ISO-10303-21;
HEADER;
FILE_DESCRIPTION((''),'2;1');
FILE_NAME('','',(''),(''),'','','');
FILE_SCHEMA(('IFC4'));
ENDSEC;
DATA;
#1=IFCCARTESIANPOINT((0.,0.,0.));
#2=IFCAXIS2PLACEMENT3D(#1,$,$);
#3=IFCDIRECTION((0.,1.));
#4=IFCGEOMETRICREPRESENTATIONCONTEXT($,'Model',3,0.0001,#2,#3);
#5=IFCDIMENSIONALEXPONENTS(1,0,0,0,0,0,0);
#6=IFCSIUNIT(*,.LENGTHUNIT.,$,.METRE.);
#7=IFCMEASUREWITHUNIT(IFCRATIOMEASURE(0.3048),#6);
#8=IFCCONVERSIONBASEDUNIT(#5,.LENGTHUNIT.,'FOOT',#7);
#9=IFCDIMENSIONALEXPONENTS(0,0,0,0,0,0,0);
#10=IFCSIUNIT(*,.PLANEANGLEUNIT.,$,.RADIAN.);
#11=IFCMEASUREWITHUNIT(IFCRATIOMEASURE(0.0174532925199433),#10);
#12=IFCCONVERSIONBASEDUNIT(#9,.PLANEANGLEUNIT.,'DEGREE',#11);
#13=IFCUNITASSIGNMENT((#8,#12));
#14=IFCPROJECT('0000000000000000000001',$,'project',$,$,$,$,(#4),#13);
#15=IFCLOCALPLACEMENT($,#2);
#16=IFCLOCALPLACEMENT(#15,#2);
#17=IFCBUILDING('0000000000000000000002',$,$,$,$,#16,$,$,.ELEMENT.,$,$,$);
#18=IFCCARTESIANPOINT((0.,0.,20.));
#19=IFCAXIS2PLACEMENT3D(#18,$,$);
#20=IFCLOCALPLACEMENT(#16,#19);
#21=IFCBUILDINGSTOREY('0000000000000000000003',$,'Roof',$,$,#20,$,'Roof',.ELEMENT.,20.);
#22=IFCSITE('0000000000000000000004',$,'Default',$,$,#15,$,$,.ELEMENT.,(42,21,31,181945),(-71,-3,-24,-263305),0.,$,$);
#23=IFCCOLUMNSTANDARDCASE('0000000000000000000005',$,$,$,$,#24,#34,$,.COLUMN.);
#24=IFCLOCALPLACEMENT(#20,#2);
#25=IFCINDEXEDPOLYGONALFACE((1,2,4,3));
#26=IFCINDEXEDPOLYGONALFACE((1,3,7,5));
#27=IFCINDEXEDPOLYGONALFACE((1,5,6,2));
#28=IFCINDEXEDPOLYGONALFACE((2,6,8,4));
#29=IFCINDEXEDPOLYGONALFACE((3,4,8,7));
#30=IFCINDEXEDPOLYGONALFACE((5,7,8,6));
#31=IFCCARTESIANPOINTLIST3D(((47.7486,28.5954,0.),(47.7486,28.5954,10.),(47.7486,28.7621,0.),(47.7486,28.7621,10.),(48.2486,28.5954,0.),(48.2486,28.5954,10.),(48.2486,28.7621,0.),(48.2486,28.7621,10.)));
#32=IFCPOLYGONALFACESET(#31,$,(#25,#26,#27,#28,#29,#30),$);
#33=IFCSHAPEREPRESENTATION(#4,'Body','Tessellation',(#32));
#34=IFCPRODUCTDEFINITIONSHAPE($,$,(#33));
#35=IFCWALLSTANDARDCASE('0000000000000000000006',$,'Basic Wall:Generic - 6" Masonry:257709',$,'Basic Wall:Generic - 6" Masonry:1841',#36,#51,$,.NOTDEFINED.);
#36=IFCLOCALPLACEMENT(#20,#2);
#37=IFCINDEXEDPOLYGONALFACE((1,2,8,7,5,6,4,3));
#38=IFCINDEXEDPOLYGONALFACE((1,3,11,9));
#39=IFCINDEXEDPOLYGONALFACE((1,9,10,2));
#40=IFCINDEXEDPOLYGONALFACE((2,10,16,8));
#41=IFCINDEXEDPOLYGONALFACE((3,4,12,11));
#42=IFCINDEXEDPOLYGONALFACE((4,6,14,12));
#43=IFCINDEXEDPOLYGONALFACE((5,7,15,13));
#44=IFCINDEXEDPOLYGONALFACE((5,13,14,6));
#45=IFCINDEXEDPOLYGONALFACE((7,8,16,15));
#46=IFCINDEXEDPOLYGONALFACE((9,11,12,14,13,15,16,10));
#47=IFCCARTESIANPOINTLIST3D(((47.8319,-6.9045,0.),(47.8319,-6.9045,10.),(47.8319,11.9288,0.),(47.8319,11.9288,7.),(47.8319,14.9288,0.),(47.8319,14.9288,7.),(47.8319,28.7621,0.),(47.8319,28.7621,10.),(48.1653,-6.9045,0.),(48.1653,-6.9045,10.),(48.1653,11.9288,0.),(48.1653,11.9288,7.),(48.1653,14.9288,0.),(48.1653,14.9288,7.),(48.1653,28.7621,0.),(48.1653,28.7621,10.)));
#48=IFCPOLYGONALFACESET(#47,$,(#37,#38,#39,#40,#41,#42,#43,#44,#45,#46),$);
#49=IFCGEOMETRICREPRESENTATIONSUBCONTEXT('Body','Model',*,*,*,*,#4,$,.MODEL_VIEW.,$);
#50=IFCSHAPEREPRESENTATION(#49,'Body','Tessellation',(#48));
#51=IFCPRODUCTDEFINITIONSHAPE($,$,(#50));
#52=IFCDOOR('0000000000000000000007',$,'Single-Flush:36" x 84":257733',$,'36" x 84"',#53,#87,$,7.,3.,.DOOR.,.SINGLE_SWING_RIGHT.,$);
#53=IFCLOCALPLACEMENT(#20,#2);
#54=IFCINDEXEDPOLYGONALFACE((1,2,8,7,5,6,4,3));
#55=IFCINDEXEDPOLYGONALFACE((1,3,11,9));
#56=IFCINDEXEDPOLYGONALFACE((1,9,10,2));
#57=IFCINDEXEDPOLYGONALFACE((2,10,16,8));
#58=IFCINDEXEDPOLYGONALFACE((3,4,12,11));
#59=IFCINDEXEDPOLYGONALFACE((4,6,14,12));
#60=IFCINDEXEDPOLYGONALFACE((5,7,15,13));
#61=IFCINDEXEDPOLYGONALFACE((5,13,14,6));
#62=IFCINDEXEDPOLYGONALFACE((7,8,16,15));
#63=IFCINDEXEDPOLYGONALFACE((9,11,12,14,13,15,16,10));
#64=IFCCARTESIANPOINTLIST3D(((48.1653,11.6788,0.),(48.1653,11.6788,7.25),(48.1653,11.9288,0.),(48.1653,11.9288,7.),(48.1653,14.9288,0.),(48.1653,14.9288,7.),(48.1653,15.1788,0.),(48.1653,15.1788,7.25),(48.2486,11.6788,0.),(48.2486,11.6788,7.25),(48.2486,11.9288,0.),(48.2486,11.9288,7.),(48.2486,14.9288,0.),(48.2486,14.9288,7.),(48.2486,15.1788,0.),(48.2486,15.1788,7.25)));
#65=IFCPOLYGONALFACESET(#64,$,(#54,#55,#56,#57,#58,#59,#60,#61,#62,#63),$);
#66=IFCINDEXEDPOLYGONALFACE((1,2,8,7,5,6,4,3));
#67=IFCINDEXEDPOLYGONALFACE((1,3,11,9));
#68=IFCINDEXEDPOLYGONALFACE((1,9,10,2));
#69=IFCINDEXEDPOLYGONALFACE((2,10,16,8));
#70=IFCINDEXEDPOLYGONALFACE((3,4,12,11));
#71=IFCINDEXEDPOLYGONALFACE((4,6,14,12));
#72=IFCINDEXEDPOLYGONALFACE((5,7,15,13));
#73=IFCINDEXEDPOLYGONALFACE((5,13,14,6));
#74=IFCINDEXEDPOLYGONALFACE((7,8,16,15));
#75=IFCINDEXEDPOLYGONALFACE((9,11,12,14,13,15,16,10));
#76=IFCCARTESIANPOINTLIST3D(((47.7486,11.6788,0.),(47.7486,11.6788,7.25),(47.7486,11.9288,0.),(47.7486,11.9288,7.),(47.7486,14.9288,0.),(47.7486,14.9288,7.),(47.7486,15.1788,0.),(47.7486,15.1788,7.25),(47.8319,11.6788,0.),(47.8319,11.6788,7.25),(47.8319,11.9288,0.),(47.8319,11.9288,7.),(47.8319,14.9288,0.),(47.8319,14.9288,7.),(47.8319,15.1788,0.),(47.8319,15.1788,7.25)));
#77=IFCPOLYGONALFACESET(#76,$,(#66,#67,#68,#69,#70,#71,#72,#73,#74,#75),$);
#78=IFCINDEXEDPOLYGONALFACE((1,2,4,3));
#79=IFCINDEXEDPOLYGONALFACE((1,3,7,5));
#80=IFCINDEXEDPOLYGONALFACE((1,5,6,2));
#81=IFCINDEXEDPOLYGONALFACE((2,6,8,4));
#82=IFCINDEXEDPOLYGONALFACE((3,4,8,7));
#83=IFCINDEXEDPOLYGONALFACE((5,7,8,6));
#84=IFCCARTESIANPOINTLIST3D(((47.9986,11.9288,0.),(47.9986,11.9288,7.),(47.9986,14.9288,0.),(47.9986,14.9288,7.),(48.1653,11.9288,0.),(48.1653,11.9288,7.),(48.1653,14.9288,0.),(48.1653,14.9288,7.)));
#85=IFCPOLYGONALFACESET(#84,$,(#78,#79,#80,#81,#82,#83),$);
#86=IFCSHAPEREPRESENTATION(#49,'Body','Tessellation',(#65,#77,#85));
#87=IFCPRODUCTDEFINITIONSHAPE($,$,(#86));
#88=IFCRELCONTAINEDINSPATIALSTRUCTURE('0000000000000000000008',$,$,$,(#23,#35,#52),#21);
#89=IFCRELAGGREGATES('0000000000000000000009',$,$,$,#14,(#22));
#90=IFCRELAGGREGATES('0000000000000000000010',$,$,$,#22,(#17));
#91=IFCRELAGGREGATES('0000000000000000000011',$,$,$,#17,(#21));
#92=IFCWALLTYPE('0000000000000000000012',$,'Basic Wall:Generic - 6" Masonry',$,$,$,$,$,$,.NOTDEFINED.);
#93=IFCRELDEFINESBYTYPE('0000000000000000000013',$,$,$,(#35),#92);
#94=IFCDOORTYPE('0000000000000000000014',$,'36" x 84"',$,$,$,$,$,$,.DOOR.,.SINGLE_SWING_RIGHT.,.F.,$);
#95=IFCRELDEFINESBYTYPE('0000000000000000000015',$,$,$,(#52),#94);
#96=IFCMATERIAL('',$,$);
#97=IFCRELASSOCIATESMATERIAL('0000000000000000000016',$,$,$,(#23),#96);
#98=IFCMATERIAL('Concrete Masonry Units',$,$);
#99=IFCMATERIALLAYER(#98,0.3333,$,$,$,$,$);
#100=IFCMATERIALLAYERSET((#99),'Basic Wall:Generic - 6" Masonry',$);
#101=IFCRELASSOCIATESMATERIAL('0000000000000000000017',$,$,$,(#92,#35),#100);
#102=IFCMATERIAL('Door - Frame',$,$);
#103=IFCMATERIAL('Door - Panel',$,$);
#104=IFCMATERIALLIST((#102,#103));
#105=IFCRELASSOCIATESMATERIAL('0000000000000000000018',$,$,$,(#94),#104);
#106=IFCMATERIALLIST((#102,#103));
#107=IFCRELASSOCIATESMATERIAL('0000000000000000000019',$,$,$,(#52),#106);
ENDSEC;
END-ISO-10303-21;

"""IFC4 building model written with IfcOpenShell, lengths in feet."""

from ifc_helpers import new_model, entity, si_unit, converted_unit, direction, frame, frame_2d, origin, place, context, subcontext, project, spatial, polyline, rectangle, outline, extrude, source, transform, mapped, material, material_list, layer, layer_set, layer_usage, type_object, type_shapes, element, fill, save


model = new_model("IFC4")

# Units and contexts
model_context = context("Model", 3, precision=0.0001, world=origin(), true_north=direction((0.0, 1.0)))
body_context = subcontext(model_context, "Body", "Model", "MODEL_VIEW")
ifc_project = project(units=[converted_unit("LENGTHUNIT", "FOOT", entity("IfcRatioMeasure", 0.3048), si_unit("LENGTHUNIT", "METRE"), dimensions=[1, 0, 0, 0, 0, 0, 0]), converted_unit("PLANEANGLEUNIT", "DEGREE", entity("IfcRatioMeasure", 0.0174532925199433), si_unit("PLANEANGLEUNIT", "RADIAN"), dimensions=[0, 0, 0, 0, 0, 0, 0])], contexts=[model_context])

# Site, building, storey
site_placement = place(None, origin())
site = spatial("IfcSite", under=ifc_project, at=site_placement, Name="Default", CompositionType="ELEMENT", RefLatitude=(42, 21, 31, 181945), RefLongitude=(-71, -3, -24, -263305), RefElevation=0.0)
building_placement = place(site_placement, origin())
building = spatial("IfcBuilding", under=site, at=building_placement, CompositionType="ELEMENT")
storey_placement = place(building_placement, frame((0.0, 0.0, 20.0)))
storey = spatial("IfcBuildingStorey", under=building, at=storey_placement, Name="Roof", LongName="Roof", CompositionType="ELEMENT", Elevation=20.0)

# Column
ifc_material_1 = material(Name="")
wall_placement = place(storey_placement, frame((47.9986, 28.7621, 0.0), z_axis=(0.0, 0.0, 1.0), x_axis=(0.0, -1.0, 0.0)))
for number, where, z_axis, x_axis in (
    (1, (0.0833, 0.0, 0.0), (0.0, 0.0, 1.0), (1.0, 0.0, 0.0)),
):
    element("IfcColumnStandardCase", number, at=place(wall_placement, frame(where, z_axis=z_axis, x_axis=x_axis)), inside=storey, material=ifc_material_1, PredefinedType="COLUMN", context=model_context, shape_type="SweptSolid", body=[
        extrude(rectangle(XDim=0.1667, YDim=0.5), origin(), (0.0, 0.0, 1.0), 10.0),
    ])

# Wall, opening, door
ifc_material_2 = material(Name="Concrete Masonry Units")
ifc_layer = layer(ifc_material_2, 0.3333)
ifc_layer_set = layer_set([ifc_layer], Name="Basic Wall:Generic - 6\" Masonry")
ifc_layer_usage = layer_usage(ifc_layer_set, "AXIS2", "NEGATIVE", 0.1667)
wall_type = type_object("IfcWallType", Name="Basic Wall:Generic - 6\" Masonry", PredefinedType="NOTDEFINED", material=ifc_layer_set)
wall = element("IfcWallStandardCase", 2, at=wall_placement, inside=storey, type_object=wall_type, material=ifc_layer_usage, Name="Basic Wall:Generic - 6\" Masonry:257709", ObjectType="Basic Wall:Generic - 6\" Masonry:1841", PredefinedType="NOTDEFINED", context=body_context, shape_type="SweptSolid", body=[
    extrude(rectangle(XDim=35.6667, YDim=0.3333, at=frame_2d((17.8333, 0.0), x_axis=(-1.0, 0.0))), origin(), (0.0, 0.0, 1.0), 10.0),
])
opening_placement = place(wall_placement, frame((13.8333, -0.1667, 0.0)))
opening = element("IfcOpeningElement", 3, at=opening_placement, cuts=wall, ObjectType="Opening", PredefinedType="OPENING", context=body_context, shape_type="SweptSolid", body=[
    extrude(rectangle(XDim=3.0, YDim=7.0, at=frame_2d((3.5, 1.5), x_axis=(0.0, 1.0))), frame((0.0, 0.0, 0.0), z_axis=(0.0, 1.0, 0.0), x_axis=(0.0, 0.0, 1.0)), (0.0, 0.0, 1.0), 0.3333),
])
ifc_material_3 = material(Name="Door - Frame")
ifc_material_4 = material(Name="Door - Panel")
ifc_material_list_1 = material_list([ifc_material_3, ifc_material_4])
ifc_material_list_2 = material_list([ifc_material_3, ifc_material_4])
door_type = type_object("IfcDoorType", Name="36\" x 84\"", OperationType="SINGLE_SWING_RIGHT", ParameterTakesPrecedence=False, PredefinedType="DOOR", material=ifc_material_list_2)
shared_shape = source(origin(), body_context, "Body", "SweptSolid", [
    extrude(outline(polyline([(-1.75, -3.6875), (1.75, -3.6875), (1.75, 3.5625), (1.5, 3.5625), (1.5, -3.4375), (-1.5, -3.4375), (-1.5, 3.5625), (-1.75, 3.5625), (-1.75, -3.6875)])), frame((1.5, 0.3333, 3.5625), z_axis=(0.0, 1.0, 0.0), x_axis=(1.0, 0.0, 0.0)), (0.0, 0.0, 1.0), 0.0833),
    extrude(outline(polyline([(-3.6875, -1.75), (3.5625, -1.75), (3.5625, -1.5), (-3.4375, -1.5), (-3.4375, 1.5), (3.5625, 1.5), (3.5625, 1.75), (-3.6875, 1.75), (-3.6875, -1.75)])), frame((1.5, -0.0833, 3.5625), z_axis=(0.0, 1.0, 0.0), x_axis=(0.0, 0.0, -1.0)), (0.0, 0.0, 1.0), 0.0833),
    extrude(rectangle(XDim=0.1667, YDim=3.0, at=frame_2d((0.0, 0.0), x_axis=(1.0, 0.0))), frame((1.5, 0.25, 0.0), z_axis=(0.0, 0.0, 1.0), x_axis=(0.0, 1.0, 0.0)), (0.0, 0.0, 1.0), 7.0),
])
type_shapes(door_type, [shared_shape])
door_placement = place(opening_placement, origin())
door = element("IfcDoor", 4, at=door_placement, inside=storey, type_object=door_type, material=ifc_material_list_1, Name="Single-Flush:36\" x 84\":257733", ObjectType="36\" x 84\"", OperationType="SINGLE_SWING_RIGHT", OverallHeight=7.0, OverallWidth=3.0, PredefinedType="DOOR", context=body_context, shape_type="MappedRepresentation", body=[
    mapped(shared_shape, transform((0.0, 0.0, 0.0), scale=1.0)),
])
fill(opening, door)

save(model, "model.ifc")
